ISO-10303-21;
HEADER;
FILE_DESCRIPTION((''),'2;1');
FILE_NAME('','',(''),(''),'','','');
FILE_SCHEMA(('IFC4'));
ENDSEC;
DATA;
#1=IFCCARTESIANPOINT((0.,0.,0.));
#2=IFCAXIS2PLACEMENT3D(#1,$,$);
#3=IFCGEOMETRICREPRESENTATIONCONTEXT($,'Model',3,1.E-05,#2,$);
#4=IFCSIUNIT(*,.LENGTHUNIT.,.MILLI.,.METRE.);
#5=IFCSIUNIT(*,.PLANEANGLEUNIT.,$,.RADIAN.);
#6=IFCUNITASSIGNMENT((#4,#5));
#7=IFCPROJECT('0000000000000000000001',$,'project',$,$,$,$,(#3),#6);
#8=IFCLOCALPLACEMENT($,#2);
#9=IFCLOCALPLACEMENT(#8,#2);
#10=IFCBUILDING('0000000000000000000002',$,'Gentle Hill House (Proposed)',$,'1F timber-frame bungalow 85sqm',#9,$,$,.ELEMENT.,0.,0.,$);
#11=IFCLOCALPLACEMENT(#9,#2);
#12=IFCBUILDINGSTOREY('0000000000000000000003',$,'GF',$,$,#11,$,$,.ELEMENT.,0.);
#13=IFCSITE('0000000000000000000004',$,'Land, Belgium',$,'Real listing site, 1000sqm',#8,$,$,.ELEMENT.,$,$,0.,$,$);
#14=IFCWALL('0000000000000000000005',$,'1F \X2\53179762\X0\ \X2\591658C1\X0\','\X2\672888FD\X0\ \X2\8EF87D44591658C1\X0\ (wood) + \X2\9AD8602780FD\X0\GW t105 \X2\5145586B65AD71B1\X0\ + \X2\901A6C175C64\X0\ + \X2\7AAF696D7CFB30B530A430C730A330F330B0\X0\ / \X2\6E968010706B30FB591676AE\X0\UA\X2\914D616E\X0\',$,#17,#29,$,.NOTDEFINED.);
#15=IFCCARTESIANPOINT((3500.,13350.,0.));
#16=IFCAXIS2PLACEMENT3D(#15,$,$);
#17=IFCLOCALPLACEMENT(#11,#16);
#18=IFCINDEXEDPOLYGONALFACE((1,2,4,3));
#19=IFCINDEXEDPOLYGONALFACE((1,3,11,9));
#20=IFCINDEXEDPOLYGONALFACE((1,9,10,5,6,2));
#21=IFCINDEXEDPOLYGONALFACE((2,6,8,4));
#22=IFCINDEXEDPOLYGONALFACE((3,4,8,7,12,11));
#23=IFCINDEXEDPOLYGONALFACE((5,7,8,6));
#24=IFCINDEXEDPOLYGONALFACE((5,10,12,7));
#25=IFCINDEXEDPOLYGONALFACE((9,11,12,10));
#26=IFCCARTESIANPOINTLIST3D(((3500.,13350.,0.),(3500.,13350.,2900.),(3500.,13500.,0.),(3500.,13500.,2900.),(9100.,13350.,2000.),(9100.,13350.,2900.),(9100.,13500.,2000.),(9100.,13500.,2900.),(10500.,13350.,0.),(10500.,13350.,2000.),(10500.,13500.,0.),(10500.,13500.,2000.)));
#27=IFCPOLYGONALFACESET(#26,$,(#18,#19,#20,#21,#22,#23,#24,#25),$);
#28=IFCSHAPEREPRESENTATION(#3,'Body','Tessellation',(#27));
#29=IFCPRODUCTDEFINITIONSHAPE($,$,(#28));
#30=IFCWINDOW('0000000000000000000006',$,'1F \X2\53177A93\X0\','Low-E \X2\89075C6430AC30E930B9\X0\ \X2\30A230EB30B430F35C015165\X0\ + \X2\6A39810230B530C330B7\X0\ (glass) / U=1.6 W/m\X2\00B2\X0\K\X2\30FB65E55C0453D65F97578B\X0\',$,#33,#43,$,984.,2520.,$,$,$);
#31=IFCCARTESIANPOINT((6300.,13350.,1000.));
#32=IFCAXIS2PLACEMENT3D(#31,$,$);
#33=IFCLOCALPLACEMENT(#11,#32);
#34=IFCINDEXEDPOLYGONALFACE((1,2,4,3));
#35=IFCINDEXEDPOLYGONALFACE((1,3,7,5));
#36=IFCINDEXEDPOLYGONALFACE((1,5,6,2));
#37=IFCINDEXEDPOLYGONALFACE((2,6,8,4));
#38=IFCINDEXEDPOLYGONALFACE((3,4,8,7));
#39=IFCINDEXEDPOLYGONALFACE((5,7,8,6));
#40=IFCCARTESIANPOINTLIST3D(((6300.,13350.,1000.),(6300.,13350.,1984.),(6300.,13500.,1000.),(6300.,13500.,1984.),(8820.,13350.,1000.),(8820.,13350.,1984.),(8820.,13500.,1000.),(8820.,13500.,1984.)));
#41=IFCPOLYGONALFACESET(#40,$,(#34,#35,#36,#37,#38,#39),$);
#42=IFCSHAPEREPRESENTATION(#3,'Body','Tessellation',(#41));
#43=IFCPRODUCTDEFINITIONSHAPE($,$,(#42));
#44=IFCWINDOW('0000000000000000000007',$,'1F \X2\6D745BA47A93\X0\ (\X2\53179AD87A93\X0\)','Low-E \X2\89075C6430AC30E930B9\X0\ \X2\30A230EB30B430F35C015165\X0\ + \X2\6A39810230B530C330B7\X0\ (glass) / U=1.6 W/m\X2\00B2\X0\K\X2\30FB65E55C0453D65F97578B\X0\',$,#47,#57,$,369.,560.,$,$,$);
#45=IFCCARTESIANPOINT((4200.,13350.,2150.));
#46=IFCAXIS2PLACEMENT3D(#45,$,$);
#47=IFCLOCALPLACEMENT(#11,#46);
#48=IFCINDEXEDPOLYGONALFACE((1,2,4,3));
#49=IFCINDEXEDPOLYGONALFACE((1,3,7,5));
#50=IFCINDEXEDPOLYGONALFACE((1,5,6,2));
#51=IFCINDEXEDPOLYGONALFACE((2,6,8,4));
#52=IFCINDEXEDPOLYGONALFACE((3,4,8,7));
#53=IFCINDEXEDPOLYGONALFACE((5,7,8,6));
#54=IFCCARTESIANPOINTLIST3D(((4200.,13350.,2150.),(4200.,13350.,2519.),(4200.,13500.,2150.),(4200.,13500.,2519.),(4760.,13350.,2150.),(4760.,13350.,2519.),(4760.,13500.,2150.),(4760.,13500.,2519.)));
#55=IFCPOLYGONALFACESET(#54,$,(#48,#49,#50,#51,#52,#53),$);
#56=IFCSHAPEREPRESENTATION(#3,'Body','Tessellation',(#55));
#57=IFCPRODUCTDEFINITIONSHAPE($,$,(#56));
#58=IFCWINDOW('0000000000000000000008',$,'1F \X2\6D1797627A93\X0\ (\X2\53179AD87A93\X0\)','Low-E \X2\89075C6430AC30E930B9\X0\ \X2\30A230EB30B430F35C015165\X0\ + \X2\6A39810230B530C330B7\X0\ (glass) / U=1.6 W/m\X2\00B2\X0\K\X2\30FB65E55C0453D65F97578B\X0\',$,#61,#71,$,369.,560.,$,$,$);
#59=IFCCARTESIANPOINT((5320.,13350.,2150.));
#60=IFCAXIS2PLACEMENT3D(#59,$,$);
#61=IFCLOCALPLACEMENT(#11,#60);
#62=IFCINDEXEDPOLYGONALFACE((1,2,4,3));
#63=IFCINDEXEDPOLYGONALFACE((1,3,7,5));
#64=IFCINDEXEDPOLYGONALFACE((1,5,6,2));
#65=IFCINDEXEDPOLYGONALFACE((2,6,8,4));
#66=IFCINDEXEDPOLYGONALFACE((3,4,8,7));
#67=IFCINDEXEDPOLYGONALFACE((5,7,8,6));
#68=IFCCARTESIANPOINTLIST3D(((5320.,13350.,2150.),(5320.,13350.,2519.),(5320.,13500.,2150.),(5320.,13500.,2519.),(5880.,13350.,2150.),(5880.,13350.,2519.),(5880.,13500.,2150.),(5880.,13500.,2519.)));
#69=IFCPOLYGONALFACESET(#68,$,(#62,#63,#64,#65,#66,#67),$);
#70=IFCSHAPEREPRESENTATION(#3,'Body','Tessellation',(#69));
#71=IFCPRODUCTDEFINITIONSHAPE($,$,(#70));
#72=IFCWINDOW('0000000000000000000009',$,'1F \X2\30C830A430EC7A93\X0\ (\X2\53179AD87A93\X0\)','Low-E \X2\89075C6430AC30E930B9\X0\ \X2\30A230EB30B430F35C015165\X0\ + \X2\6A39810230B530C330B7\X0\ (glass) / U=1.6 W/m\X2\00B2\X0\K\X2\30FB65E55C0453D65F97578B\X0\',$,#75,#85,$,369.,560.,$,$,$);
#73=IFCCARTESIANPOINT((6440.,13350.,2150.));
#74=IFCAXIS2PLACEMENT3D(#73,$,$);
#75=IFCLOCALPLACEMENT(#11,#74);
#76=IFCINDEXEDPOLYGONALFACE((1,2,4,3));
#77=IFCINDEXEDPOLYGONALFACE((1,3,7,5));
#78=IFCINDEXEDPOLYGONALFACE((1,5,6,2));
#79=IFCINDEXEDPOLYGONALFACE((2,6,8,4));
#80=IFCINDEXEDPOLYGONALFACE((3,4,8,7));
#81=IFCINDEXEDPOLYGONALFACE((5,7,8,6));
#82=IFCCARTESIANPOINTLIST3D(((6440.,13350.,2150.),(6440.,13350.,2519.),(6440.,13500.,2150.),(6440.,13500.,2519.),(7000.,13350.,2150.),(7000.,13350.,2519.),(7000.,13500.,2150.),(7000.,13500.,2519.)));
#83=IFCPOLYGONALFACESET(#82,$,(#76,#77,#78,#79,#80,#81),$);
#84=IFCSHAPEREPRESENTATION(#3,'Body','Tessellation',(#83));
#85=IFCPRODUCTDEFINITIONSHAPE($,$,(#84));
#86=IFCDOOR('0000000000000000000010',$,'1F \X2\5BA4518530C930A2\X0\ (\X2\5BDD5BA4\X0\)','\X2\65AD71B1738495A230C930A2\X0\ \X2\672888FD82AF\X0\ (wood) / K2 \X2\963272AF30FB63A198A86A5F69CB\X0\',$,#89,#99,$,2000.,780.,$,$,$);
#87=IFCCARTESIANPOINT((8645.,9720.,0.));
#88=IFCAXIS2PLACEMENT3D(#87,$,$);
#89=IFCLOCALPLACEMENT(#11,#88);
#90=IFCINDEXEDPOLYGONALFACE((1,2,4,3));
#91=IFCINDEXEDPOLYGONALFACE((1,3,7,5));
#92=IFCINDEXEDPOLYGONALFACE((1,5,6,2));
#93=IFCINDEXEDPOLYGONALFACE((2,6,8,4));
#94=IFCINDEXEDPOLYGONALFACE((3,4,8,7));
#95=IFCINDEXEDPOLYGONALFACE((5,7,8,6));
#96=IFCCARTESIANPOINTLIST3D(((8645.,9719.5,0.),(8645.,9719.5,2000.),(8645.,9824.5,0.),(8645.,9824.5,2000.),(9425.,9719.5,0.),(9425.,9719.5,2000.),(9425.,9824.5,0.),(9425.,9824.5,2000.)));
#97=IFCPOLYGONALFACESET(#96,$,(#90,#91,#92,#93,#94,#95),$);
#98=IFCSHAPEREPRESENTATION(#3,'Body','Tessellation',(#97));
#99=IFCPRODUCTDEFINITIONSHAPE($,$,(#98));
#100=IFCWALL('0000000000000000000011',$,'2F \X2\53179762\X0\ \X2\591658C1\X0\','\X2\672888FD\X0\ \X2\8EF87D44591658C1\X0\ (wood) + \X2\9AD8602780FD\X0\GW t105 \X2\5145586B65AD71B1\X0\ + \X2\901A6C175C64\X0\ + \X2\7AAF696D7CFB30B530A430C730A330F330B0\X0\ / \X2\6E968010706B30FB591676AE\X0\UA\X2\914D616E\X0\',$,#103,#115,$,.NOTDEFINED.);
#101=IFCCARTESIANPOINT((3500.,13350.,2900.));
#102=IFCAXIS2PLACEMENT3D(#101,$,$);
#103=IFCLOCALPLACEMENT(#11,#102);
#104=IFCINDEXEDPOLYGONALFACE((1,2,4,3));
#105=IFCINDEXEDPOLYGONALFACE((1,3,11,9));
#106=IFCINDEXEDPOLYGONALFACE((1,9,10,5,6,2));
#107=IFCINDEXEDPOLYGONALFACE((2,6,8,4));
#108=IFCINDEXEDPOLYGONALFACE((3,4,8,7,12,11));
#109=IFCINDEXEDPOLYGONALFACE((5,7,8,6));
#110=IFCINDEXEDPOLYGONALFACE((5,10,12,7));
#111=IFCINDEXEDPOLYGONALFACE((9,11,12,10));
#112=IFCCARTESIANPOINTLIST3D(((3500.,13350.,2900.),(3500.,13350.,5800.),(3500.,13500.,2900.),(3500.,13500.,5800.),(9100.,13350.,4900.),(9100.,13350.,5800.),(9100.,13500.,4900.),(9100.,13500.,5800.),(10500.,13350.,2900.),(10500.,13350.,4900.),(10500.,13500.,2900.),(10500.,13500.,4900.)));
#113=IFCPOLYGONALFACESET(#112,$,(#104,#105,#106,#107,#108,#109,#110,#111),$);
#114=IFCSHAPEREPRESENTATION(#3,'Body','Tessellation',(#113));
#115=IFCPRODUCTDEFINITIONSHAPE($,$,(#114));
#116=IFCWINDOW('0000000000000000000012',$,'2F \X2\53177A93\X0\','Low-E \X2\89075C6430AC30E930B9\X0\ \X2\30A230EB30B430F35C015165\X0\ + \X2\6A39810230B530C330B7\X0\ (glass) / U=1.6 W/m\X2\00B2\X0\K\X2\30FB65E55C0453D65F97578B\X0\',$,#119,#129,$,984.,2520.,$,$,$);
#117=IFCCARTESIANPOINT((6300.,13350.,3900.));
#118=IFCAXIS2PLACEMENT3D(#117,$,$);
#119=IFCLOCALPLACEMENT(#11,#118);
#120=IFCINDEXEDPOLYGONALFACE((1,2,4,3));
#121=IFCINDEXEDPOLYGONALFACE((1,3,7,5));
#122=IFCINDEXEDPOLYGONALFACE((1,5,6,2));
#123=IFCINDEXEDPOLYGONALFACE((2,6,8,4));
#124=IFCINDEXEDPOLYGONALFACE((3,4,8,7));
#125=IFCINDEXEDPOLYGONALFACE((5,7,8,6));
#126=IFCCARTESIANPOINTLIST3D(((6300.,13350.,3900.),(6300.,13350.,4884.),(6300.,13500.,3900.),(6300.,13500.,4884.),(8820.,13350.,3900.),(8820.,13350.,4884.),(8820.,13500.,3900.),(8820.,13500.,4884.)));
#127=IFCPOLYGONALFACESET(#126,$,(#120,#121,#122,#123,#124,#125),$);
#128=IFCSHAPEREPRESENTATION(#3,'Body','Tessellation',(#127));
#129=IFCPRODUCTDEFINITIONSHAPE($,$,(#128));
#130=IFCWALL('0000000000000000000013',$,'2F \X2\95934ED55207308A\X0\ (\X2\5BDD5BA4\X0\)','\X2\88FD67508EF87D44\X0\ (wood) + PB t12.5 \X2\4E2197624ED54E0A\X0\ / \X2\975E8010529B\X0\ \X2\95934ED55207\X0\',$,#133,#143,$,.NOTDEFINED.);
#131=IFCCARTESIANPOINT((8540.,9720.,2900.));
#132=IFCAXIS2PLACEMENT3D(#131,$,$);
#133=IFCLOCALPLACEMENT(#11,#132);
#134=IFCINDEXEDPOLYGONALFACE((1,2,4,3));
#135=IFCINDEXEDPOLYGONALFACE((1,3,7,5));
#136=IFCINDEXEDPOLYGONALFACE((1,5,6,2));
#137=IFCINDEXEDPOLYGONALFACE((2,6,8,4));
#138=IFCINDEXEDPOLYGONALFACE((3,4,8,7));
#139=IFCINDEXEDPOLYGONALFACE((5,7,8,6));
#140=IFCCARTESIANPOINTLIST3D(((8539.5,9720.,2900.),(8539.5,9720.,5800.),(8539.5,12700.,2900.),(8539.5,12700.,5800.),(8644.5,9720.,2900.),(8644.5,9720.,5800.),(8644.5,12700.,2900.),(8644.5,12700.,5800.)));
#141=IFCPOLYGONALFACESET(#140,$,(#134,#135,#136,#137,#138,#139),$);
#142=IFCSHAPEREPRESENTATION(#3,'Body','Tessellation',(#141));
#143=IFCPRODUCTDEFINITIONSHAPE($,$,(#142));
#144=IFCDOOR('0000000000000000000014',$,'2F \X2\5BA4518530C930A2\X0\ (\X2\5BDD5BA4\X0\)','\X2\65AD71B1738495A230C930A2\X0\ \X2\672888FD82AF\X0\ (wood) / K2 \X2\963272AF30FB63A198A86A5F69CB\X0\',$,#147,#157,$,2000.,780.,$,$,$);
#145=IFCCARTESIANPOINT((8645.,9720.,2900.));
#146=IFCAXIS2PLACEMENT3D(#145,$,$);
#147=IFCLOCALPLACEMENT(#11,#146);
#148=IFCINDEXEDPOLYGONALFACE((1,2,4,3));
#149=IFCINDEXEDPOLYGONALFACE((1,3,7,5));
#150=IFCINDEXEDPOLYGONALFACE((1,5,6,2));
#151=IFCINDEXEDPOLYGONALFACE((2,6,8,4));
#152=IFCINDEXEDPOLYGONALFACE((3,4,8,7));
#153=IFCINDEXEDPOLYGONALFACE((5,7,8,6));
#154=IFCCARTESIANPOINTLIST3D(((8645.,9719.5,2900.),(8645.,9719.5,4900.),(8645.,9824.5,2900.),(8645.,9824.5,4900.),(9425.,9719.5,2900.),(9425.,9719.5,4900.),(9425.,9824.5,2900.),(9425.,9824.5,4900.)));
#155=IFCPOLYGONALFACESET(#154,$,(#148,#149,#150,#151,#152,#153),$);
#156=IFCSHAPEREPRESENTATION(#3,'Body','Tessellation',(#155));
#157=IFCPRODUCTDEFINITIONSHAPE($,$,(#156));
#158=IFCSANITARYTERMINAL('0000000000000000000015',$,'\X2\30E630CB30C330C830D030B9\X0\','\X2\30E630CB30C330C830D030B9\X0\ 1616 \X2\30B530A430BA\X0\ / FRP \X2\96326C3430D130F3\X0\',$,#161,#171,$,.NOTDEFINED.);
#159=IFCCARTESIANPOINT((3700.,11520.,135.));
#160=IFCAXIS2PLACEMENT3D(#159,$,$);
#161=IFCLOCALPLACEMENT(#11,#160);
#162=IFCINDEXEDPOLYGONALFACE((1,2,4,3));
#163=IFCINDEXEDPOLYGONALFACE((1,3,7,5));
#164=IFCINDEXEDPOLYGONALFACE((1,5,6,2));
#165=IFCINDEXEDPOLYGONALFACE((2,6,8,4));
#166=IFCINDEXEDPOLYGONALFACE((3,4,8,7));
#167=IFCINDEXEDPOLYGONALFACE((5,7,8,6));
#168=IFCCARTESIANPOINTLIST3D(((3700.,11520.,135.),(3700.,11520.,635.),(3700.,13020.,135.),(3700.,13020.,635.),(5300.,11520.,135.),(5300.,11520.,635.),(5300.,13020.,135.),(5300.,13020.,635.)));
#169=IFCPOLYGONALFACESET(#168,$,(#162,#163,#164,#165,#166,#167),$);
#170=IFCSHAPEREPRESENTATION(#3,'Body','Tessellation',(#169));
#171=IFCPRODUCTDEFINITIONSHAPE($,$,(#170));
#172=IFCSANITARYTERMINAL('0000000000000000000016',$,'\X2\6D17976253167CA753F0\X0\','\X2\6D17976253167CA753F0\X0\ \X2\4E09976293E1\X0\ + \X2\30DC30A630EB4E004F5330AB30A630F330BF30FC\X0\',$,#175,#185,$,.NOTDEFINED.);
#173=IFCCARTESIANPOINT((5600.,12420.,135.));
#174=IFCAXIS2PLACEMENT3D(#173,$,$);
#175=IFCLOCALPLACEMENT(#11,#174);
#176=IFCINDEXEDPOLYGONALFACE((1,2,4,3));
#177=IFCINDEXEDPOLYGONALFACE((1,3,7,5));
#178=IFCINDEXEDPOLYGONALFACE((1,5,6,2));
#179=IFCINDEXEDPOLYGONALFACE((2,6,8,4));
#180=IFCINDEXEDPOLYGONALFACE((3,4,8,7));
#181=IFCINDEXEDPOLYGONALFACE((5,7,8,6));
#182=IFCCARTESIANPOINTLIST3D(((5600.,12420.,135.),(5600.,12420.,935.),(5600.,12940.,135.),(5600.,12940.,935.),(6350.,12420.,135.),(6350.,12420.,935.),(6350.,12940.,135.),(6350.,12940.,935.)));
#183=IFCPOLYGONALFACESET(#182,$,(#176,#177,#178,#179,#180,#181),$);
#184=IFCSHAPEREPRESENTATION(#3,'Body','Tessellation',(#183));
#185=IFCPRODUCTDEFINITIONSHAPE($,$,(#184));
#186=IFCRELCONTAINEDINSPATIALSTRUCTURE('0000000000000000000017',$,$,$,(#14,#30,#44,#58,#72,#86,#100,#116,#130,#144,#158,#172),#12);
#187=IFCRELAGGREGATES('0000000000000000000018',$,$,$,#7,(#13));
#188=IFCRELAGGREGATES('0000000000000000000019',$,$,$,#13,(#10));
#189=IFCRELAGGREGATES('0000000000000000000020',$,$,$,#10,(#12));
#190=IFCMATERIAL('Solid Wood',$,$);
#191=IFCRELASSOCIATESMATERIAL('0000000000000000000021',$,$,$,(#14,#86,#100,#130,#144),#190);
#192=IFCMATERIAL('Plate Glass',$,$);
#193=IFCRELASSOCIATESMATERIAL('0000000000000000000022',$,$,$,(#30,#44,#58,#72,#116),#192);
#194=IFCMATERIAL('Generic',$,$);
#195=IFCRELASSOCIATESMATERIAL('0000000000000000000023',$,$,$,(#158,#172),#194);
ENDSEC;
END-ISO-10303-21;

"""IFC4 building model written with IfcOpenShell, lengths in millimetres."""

from ifc_helpers import new_model, si_unit, frame, frame_2d, origin, place, context, project, spatial, rectangle, extrude, material, element, fill, save


model = new_model("IFC4")

# Units and contexts
model_context = context("Model", 3, precision=1e-05, world=origin())
ifc_project = project(units=[si_unit("LENGTHUNIT", "METRE", prefix="MILLI"), si_unit("PLANEANGLEUNIT", "RADIAN")], contexts=[model_context])

# Site, building, storey
site_placement = place(None, origin())
site = spatial("IfcSite", under=ifc_project, at=site_placement, Name="Land, Belgium", ObjectType="Real listing site, 1000sqm", CompositionType="ELEMENT", RefElevation=0.0)
building_placement = place(site_placement, origin())
building = spatial("IfcBuilding", under=site, at=building_placement, Name="Gentle Hill House (Proposed)", ObjectType="1F timber-frame bungalow 85sqm", CompositionType="ELEMENT", ElevationOfRefHeight=0.0, ElevationOfTerrain=0.0)
storey_placement = place(building_placement, origin())
storey = spatial("IfcBuildingStorey", under=building, at=storey_placement, Name="GF", CompositionType="ELEMENT", Elevation=0.0)

# Wall, openings, windows
ifc_material_1 = material(Name="Solid Wood")
wall_1_placement = place(storey_placement, frame((3500.0, 13350.0, 0.0)))
wall_1 = element("IfcWall", 1, at=wall_1_placement, inside=storey, material=ifc_material_1, Name="1F 北面 外壁", Description="木製 軸組外壁 (wood) + 高性能GW t105 充填断熱 + 通気層 + 窯業系サイディング / 準耐火・外皮UA配慮", PredefinedType="NOTDEFINED", context=model_context, shape_type="SweptSolid", body=[
    extrude(rectangle(XDim=7000.0, YDim=150.0, at=frame_2d((3500.0, 75.0))), frame((3500.0, 13350.0, 0.0)), (0.0, 0.0, 1.0), 2900.0),
])
opening_1_placement = place(storey_placement, frame((6300.0, 13350.0, 1000.0)))
opening_1 = element("IfcOpeningElement", 2, at=opening_1_placement, cuts=wall_1, PredefinedType="NOTDEFINED", context=model_context, shape_type="SweptSolid", body=[
    extrude(rectangle(XDim=2520.0, YDim=150.0, at=frame_2d((1260.0, 75.0))), frame((6300.0, 13350.0, 1000.0)), (0.0, 0.0, 1.0), 984.0),
])
opening_2_placement = place(storey_placement, frame((4200.0, 13350.0, 2150.0)))
opening_2 = element("IfcOpeningElement", 3, at=opening_2_placement, cuts=wall_1, PredefinedType="NOTDEFINED", context=model_context, shape_type="SweptSolid", body=[
    extrude(rectangle(XDim=560.0, YDim=150.0, at=frame_2d((280.0, 75.0))), frame((4200.0, 13350.0, 2150.0)), (0.0, 0.0, 1.0), 369.0),
])
opening_3_placement = place(storey_placement, frame((5320.0, 13350.0, 2150.0)))
opening_3 = element("IfcOpeningElement", 4, at=opening_3_placement, cuts=wall_1, PredefinedType="NOTDEFINED", context=model_context, shape_type="SweptSolid", body=[
    extrude(rectangle(XDim=560.0, YDim=150.0, at=frame_2d((280.0, 75.0))), frame((5320.0, 13350.0, 2150.0)), (0.0, 0.0, 1.0), 369.0),
])
opening_4_placement = place(storey_placement, frame((6440.0, 13350.0, 2150.0)))
opening_4 = element("IfcOpeningElement", 5, at=opening_4_placement, cuts=wall_1, PredefinedType="NOTDEFINED", context=model_context, shape_type="SweptSolid", body=[
    extrude(rectangle(XDim=560.0, YDim=150.0, at=frame_2d((280.0, 75.0))), frame((6440.0, 13350.0, 2150.0)), (0.0, 0.0, 1.0), 369.0),
])
ifc_material_2 = material(Name="Plate Glass")
window_1_placement = place(storey_placement, frame((6300.0, 13350.0, 1000.0)))
window_1 = element("IfcWindow", 6, at=window_1_placement, inside=storey, material=ifc_material_2, Name="1F 北窓", Description="Low-E 複層ガラス アルゴン封入 + 樹脂サッシ (glass) / U=1.6 W/m²K・日射取得型", OverallHeight=984.0, OverallWidth=2520.0, context=model_context, shape_type="SweptSolid", body=[
    extrude(rectangle(XDim=2520.0, YDim=150.0, at=frame_2d((1260.0, 75.0))), frame((6300.0, 13350.0, 1000.0)), (0.0, 0.0, 1.0), 984.0),
])
fill(opening_1, window_1)
window_2_placement = place(storey_placement, frame((4200.0, 13350.0, 2150.0)))
window_2 = element("IfcWindow", 7, at=window_2_placement, inside=storey, material=ifc_material_2, Name="1F 浴室窓 (北高窓)", Description="Low-E 複層ガラス アルゴン封入 + 樹脂サッシ (glass) / U=1.6 W/m²K・日射取得型", OverallHeight=369.0, OverallWidth=560.0, context=model_context, shape_type="SweptSolid", body=[
    extrude(rectangle(XDim=560.0, YDim=150.0, at=frame_2d((280.0, 75.0))), frame((4200.0, 13350.0, 2150.0)), (0.0, 0.0, 1.0), 369.0),
])
fill(opening_2, window_2)
window_3_placement = place(storey_placement, frame((5320.0, 13350.0, 2150.0)))
window_3 = element("IfcWindow", 8, at=window_3_placement, inside=storey, material=ifc_material_2, Name="1F 洗面窓 (北高窓)", Description="Low-E 複層ガラス アルゴン封入 + 樹脂サッシ (glass) / U=1.6 W/m²K・日射取得型", OverallHeight=369.0, OverallWidth=560.0, context=model_context, shape_type="SweptSolid", body=[
    extrude(rectangle(XDim=560.0, YDim=150.0, at=frame_2d((280.0, 75.0))), frame((5320.0, 13350.0, 2150.0)), (0.0, 0.0, 1.0), 369.0),
])
fill(opening_3, window_3)
window_4_placement = place(storey_placement, frame((6440.0, 13350.0, 2150.0)))
window_4 = element("IfcWindow", 9, at=window_4_placement, inside=storey, material=ifc_material_2, Name="1F トイレ窓 (北高窓)", Description="Low-E 複層ガラス アルゴン封入 + 樹脂サッシ (glass) / U=1.6 W/m²K・日射取得型", OverallHeight=369.0, OverallWidth=560.0, context=model_context, shape_type="SweptSolid", body=[
    extrude(rectangle(XDim=560.0, YDim=150.0, at=frame_2d((280.0, 75.0))), frame((6440.0, 13350.0, 2150.0)), (0.0, 0.0, 1.0), 369.0),
])
fill(opening_4, window_4)

# Door
door_1_placement = place(storey_placement, frame((8645.0, 9720.0, 0.0)))
element("IfcDoor", 10, at=door_1_placement, inside=storey, material=ifc_material_1, Name="1F 室内ドア (寝室)", Description="断熱玄関ドア 木製芯 (wood) / K2 防犯・採風機構", OverallHeight=2000.0, OverallWidth=780.0, context=model_context, shape_type="SweptSolid", body=[
    extrude(rectangle(XDim=780.0, YDim=105.0, at=frame_2d((390.0, 52.0))), frame((8645.0, 9720.0, 0.0)), (0.0, 0.0, 1.0), 2000.0),
])

# Wall, opening, window
wall_2_placement = place(storey_placement, frame((3500.0, 13350.0, 2900.0)))
wall_2 = element("IfcWall", 11, at=wall_2_placement, inside=storey, material=ifc_material_1, Name="2F 北面 外壁", Description="木製 軸組外壁 (wood) + 高性能GW t105 充填断熱 + 通気層 + 窯業系サイディング / 準耐火・外皮UA配慮", PredefinedType="NOTDEFINED", context=model_context, shape_type="SweptSolid", body=[
    extrude(rectangle(XDim=7000.0, YDim=150.0, at=frame_2d((3500.0, 75.0))), frame((3500.0, 13350.0, 2900.0)), (0.0, 0.0, 1.0), 2900.0),
])
opening_5_placement = place(storey_placement, frame((6300.0, 13350.0, 3900.0)))
opening_5 = element("IfcOpeningElement", 12, at=opening_5_placement, cuts=wall_2, PredefinedType="NOTDEFINED", context=model_context, shape_type="SweptSolid", body=[
    extrude(rectangle(XDim=2520.0, YDim=150.0, at=frame_2d((1260.0, 75.0))), frame((6300.0, 13350.0, 3900.0)), (0.0, 0.0, 1.0), 984.0),
])
window_5_placement = place(storey_placement, frame((6300.0, 13350.0, 3900.0)))
window_5 = element("IfcWindow", 13, at=window_5_placement, inside=storey, material=ifc_material_2, Name="2F 北窓", Description="Low-E 複層ガラス アルゴン封入 + 樹脂サッシ (glass) / U=1.6 W/m²K・日射取得型", OverallHeight=984.0, OverallWidth=2520.0, context=model_context, shape_type="SweptSolid", body=[
    extrude(rectangle(XDim=2520.0, YDim=150.0, at=frame_2d((1260.0, 75.0))), frame((6300.0, 13350.0, 3900.0)), (0.0, 0.0, 1.0), 984.0),
])
fill(opening_5, window_5)

# Wall
wall_3_placement = place(storey_placement, frame((8540.0, 9720.0, 2900.0)))
element("IfcWall", 14, at=wall_3_placement, inside=storey, material=ifc_material_1, Name="2F 間仕切り (寝室)", Description="製材軸組 (wood) + PB t12.5 両面仕上 / 非耐力 間仕切", PredefinedType="NOTDEFINED", context=model_context, shape_type="SweptSolid", body=[
    extrude(rectangle(XDim=105.0, YDim=2980.0, at=frame_2d((52.0, 1490.0))), frame((8540.0, 9720.0, 2900.0)), (0.0, 0.0, 1.0), 2900.0),
])

# Door
door_2_placement = place(storey_placement, frame((8645.0, 9720.0, 2900.0)))
element("IfcDoor", 15, at=door_2_placement, inside=storey, material=ifc_material_1, Name="2F 室内ドア (寝室)", Description="断熱玄関ドア 木製芯 (wood) / K2 防犯・採風機構", OverallHeight=2000.0, OverallWidth=780.0, context=model_context, shape_type="SweptSolid", body=[
    extrude(rectangle(XDim=780.0, YDim=105.0, at=frame_2d((390.0, 52.0))), frame((8645.0, 9720.0, 2900.0)), (0.0, 0.0, 1.0), 2000.0),
])

# Sanitary terminals
ifc_material_3 = material(Name="Generic")
sanitary_terminal_1_placement = place(storey_placement, frame((3700.0, 11520.0, 135.0)))
element("IfcSanitaryTerminal", 16, at=sanitary_terminal_1_placement, inside=storey, material=ifc_material_3, Name="ユニットバス", Description="ユニットバス 1616 サイズ / FRP 防水パン", PredefinedType="NOTDEFINED", context=model_context, shape_type="SweptSolid", body=[
    extrude(rectangle(XDim=1600.0, YDim=1500.0, at=frame_2d((800.0, 750.0))), frame((3700.0, 11520.0, 135.0)), (0.0, 0.0, 1.0), 500.0),
])
sanitary_terminal_2_placement = place(storey_placement, frame((5600.0, 12420.0, 135.0)))
element("IfcSanitaryTerminal", 17, at=sanitary_terminal_2_placement, inside=storey, material=ifc_material_3, Name="洗面化粧台", Description="洗面化粧台 三面鏡 + ボウル一体カウンター", PredefinedType="NOTDEFINED", context=model_context, shape_type="SweptSolid", body=[
    extrude(rectangle(XDim=750.0, YDim=520.0, at=frame_2d((375.0, 260.0))), frame((5600.0, 12420.0, 135.0)), (0.0, 0.0, 1.0), 800.0),
])

save(model, "model.ifc")
